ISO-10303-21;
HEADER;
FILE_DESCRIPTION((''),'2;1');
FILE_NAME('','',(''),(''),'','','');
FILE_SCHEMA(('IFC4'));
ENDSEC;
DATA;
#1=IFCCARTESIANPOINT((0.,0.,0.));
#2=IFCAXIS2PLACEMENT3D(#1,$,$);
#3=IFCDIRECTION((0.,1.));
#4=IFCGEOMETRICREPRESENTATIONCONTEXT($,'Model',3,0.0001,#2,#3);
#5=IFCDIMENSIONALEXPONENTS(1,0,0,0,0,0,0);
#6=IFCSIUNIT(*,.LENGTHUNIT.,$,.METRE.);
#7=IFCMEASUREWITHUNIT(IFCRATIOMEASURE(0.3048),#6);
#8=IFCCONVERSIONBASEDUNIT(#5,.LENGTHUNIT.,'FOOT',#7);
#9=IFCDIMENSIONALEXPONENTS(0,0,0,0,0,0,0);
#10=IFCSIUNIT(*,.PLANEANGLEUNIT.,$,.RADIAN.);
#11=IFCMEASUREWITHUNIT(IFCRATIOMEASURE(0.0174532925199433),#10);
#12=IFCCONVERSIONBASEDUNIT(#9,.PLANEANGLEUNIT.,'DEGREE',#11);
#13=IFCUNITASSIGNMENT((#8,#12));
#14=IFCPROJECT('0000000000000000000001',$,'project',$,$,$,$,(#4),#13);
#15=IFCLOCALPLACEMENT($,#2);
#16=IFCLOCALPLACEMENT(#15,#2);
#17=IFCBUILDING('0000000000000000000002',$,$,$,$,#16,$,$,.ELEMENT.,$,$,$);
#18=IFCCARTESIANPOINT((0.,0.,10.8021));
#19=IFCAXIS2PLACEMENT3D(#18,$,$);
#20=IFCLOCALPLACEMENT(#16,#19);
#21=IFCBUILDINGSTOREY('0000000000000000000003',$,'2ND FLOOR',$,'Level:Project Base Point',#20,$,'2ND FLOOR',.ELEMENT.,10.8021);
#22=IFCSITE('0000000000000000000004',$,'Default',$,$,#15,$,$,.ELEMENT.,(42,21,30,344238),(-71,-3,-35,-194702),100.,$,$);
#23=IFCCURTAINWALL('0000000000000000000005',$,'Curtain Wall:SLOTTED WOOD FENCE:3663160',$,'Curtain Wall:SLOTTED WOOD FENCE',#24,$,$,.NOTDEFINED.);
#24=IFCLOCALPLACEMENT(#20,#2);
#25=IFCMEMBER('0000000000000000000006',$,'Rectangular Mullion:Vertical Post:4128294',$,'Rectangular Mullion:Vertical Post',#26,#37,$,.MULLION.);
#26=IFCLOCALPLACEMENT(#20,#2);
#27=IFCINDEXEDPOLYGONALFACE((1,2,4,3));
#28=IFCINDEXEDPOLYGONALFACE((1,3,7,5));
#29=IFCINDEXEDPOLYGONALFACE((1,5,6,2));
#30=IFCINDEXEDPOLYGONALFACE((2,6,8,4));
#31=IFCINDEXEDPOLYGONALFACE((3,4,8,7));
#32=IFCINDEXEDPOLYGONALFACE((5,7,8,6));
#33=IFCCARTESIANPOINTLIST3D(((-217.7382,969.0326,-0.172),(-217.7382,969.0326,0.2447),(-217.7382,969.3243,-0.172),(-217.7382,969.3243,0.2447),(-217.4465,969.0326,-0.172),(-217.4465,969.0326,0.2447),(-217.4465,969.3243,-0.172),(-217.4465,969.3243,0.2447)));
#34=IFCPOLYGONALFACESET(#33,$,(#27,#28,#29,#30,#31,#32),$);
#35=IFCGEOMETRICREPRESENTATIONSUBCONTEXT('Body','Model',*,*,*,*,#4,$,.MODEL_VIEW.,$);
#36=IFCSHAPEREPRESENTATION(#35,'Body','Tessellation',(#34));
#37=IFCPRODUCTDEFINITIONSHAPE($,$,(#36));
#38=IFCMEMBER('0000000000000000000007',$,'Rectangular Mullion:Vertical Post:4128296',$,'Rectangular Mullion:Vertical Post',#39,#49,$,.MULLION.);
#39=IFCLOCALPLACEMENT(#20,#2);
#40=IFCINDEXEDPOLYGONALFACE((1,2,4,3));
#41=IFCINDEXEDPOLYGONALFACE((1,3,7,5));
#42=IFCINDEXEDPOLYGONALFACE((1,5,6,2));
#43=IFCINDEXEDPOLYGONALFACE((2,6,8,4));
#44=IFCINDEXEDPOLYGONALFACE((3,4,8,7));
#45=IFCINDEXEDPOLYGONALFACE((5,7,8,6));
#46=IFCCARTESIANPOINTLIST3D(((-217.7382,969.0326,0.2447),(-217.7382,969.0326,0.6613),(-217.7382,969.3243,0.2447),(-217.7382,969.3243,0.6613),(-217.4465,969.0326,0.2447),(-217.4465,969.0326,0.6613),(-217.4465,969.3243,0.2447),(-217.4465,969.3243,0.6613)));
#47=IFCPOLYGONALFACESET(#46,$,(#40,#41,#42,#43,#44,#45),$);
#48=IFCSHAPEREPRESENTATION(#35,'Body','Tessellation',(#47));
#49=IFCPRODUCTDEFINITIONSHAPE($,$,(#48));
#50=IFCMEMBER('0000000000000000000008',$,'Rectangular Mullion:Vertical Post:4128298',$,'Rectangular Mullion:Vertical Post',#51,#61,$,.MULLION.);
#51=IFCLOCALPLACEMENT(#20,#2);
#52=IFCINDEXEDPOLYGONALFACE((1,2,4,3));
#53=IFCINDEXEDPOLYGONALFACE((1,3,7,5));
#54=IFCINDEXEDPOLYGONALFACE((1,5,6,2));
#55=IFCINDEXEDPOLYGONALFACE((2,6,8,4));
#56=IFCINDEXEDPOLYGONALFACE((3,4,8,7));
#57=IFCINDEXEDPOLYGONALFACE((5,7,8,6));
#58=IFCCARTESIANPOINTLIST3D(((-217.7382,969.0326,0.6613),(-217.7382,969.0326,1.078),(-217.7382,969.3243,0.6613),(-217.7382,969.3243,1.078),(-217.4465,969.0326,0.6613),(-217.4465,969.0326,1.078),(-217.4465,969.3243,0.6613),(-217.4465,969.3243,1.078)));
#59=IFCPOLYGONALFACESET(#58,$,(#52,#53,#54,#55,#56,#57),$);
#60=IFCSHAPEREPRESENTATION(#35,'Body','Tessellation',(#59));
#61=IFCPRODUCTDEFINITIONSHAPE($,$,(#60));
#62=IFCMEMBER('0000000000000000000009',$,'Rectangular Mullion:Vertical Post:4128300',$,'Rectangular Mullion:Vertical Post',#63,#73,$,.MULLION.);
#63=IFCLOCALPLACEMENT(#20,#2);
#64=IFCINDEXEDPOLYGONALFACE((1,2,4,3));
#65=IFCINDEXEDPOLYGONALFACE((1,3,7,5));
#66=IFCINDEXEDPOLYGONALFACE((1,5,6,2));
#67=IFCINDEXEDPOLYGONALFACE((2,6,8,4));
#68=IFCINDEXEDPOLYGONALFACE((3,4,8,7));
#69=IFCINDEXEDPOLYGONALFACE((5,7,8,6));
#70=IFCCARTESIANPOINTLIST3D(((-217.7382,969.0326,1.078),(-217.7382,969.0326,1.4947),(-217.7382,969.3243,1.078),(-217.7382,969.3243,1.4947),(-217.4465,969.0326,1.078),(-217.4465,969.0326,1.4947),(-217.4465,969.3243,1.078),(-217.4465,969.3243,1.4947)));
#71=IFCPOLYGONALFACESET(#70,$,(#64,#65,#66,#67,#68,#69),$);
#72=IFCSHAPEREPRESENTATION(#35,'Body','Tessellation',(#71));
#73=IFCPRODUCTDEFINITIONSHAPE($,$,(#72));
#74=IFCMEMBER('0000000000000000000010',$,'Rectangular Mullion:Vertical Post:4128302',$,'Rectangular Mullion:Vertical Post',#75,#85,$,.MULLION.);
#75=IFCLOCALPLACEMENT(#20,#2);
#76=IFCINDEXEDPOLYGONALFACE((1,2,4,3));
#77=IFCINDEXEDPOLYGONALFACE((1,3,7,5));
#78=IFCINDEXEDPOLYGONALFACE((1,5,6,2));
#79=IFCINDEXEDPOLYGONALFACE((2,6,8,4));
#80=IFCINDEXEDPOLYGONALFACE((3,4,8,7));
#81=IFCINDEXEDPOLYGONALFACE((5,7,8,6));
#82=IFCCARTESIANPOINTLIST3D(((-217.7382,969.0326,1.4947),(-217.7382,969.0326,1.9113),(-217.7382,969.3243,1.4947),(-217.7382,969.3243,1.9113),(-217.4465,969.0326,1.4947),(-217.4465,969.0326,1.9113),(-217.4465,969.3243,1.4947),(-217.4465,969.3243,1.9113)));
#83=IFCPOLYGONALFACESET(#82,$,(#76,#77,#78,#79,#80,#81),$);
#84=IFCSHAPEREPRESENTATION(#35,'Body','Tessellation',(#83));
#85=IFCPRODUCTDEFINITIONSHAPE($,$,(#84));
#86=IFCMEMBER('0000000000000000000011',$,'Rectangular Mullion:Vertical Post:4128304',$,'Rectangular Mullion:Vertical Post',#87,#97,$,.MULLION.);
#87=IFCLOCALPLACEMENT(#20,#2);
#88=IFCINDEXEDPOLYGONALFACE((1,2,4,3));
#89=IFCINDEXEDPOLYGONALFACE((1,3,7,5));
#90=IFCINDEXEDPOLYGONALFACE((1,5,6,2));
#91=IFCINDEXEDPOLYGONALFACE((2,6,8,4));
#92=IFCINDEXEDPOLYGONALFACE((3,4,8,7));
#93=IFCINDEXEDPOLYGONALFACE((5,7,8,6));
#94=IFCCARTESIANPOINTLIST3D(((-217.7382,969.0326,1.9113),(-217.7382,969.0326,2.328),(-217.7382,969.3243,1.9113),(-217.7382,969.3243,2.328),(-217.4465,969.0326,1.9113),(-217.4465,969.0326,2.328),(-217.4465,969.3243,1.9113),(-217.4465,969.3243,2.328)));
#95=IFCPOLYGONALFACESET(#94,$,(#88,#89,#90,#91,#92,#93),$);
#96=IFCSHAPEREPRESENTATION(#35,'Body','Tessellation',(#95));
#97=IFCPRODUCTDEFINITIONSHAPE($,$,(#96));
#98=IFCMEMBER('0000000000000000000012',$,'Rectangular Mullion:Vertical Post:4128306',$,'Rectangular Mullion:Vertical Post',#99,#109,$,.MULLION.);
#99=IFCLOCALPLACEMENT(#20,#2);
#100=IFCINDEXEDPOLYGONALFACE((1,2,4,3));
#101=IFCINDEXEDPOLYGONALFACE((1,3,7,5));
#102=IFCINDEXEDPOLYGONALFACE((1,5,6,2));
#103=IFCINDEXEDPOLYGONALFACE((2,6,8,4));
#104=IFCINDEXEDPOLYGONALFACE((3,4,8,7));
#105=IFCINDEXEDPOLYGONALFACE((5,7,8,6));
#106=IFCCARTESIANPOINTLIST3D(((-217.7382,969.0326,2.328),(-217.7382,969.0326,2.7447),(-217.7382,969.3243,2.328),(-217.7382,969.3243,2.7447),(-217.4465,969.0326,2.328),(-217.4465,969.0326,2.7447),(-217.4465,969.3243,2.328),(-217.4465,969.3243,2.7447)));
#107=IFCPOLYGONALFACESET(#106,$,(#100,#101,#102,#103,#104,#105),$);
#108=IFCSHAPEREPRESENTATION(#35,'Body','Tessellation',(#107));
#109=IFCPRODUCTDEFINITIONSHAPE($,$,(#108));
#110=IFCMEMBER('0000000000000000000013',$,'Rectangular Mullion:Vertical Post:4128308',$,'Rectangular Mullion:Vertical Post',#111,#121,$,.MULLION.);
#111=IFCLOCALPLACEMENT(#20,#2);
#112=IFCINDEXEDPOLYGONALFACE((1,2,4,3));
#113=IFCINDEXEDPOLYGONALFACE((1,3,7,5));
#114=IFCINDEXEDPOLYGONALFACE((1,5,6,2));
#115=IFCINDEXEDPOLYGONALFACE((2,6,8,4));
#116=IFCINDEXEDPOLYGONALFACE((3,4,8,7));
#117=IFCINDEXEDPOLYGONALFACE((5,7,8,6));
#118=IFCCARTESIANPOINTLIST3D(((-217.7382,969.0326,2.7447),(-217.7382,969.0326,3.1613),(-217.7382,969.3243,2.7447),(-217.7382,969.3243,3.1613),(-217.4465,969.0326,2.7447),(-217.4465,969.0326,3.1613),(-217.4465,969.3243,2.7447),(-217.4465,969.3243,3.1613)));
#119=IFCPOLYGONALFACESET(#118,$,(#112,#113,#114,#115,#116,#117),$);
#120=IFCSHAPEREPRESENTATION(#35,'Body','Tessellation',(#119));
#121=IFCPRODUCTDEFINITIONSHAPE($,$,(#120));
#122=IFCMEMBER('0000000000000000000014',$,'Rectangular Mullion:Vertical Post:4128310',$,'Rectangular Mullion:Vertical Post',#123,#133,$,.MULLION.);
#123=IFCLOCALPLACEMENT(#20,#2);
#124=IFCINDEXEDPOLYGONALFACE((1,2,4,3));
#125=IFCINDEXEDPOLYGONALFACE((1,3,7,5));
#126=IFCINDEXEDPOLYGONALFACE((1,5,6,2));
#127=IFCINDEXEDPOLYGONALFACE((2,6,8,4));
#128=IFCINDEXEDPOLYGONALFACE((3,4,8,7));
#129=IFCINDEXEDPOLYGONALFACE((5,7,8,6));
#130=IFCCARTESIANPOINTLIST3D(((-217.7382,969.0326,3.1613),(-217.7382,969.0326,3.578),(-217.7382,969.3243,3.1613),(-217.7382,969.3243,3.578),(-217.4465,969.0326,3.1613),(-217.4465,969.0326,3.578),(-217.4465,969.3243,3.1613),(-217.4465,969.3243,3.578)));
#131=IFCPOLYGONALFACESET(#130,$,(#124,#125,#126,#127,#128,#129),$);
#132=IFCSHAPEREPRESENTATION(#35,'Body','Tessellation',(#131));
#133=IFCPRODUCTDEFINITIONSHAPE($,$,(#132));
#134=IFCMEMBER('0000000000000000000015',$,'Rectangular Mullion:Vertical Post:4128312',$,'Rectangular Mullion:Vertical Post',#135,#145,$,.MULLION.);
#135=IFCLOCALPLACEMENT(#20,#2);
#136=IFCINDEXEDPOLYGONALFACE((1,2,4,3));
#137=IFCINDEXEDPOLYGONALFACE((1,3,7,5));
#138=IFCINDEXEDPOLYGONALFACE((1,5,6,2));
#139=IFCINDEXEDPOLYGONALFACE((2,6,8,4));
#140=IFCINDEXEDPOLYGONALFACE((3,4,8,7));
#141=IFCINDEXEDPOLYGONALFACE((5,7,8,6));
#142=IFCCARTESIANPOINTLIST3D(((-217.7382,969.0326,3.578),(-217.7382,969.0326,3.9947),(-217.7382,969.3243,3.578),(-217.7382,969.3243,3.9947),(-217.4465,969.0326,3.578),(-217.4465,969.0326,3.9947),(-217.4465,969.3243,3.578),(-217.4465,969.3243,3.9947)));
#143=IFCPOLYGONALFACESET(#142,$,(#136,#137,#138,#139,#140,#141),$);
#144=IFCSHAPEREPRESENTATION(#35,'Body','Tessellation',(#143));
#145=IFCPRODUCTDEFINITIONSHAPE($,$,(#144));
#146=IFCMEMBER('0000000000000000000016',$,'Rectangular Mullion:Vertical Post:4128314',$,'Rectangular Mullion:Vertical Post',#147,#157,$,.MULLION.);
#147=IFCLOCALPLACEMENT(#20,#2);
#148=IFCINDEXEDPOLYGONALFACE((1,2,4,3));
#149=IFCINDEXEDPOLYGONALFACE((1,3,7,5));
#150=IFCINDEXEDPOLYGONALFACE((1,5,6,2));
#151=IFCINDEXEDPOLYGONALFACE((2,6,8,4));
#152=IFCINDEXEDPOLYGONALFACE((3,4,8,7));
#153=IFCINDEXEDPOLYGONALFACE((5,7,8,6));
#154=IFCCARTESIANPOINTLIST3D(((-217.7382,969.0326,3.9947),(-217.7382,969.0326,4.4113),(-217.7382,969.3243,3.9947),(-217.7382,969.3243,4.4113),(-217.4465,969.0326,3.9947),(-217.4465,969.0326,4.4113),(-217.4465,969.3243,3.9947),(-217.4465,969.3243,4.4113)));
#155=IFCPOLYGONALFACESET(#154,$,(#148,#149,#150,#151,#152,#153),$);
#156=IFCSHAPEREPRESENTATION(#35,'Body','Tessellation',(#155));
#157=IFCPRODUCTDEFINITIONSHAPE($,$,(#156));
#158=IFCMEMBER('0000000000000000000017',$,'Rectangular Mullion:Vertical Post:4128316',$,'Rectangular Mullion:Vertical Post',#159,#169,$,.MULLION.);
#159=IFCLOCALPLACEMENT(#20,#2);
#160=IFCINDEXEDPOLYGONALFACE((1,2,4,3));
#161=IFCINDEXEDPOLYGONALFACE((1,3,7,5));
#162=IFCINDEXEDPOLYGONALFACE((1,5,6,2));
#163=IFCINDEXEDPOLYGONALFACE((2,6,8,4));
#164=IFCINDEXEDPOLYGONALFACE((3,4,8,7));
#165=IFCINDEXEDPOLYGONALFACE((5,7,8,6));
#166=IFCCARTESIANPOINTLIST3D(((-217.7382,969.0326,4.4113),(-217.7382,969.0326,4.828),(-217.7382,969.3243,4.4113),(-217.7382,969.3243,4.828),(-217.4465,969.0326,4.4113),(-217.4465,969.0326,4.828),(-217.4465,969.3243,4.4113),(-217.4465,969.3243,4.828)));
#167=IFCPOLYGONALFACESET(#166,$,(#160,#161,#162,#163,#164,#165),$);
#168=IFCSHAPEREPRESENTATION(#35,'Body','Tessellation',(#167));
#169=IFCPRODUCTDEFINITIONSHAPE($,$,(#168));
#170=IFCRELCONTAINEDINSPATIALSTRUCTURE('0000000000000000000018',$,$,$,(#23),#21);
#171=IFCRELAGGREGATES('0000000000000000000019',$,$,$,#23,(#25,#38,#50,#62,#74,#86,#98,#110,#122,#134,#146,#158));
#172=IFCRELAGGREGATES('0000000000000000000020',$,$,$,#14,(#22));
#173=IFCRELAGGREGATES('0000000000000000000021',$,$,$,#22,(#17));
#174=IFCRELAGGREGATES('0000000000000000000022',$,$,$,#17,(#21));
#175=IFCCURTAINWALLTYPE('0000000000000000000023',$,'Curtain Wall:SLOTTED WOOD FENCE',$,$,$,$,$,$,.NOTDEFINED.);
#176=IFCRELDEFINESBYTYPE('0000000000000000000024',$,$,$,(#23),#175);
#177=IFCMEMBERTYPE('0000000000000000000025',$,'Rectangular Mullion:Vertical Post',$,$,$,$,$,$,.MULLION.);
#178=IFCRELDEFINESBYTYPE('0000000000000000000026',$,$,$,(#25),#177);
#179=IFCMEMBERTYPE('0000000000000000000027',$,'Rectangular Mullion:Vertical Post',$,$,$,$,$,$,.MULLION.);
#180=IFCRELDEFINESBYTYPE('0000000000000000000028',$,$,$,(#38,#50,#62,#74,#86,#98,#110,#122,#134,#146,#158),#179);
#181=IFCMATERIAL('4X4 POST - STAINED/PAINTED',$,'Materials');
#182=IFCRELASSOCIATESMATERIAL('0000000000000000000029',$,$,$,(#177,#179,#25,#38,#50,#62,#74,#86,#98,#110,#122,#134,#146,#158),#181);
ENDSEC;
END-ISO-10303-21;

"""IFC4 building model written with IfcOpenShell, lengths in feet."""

from ifc_helpers import new_model, entity, si_unit, converted_unit, direction, frame, origin, origin_2d_with_axis, place, context, subcontext, project, spatial, rectangle, extrude, source, transform, mapped, material, material_profile, profile_set, profile_usage, type_object, type_shapes, element, aggregate, save


model = new_model("IFC4")

# Units and contexts
model_context = context("Model", 3, precision=0.0001, world=origin(), true_north=direction((0.0, 1.0)))
body_context = subcontext(model_context, "Body", "Model", "MODEL_VIEW")
ifc_project = project(units=[converted_unit("LENGTHUNIT", "FOOT", entity("IfcRatioMeasure", 0.3048), si_unit("LENGTHUNIT", "METRE"), dimensions=[1, 0, 0, 0, 0, 0, 0]), converted_unit("PLANEANGLEUNIT", "DEGREE", entity("IfcRatioMeasure", 0.0174532925199433), si_unit("PLANEANGLEUNIT", "RADIAN"), dimensions=[0, 0, 0, 0, 0, 0, 0])], contexts=[model_context])

# Site, building, storey
site_placement = place(None, origin())
site = spatial("IfcSite", under=ifc_project, at=site_placement, Name="Default", CompositionType="ELEMENT", RefLatitude=(42, 21, 30, 344238), RefLongitude=(-71, -3, -35, -194702), RefElevation=100.0)
building_placement = place(site_placement, origin())
building = spatial("IfcBuilding", under=site, at=building_placement, CompositionType="ELEMENT")
storey_placement = place(building_placement, frame((0.0, 0.0, 10.8021)))
storey = spatial("IfcBuildingStorey", under=building, at=storey_placement, Name="2ND FLOOR", ObjectType="Level:Project Base Point", LongName="2ND FLOOR", CompositionType="ELEMENT", Elevation=10.8021)

# Curtain wall, members
curtain_wall_type = type_object("IfcCurtainWallType", Name="Curtain Wall:SLOTTED WOOD FENCE", PredefinedType="NOTDEFINED")
curtain_wall_placement = place(storey_placement, frame((0.0, 0.0, -10.8021)))
curtain_wall = element("IfcCurtainWall", 1, at=curtain_wall_placement, inside=storey, type_object=curtain_wall_type, Name="Curtain Wall:SLOTTED WOOD FENCE:3663160", ObjectType="Curtain Wall:SLOTTED WOOD FENCE", PredefinedType="NOTDEFINED")
ifc_material_1 = material(Name="4X4 POST - STAINED/PAINTED", Category="Materials")
ifc_material_profile = material_profile(ifc_material_1, rectangle(XDim=0.2917, YDim=0.2917, at=origin_2d_with_axis()), Name="Vertical Post")
ifc_profile_set = profile_set([ifc_material_profile], Name="Vertical Post")
ifc_profile_usage_1 = profile_usage(ifc_profile_set)
member_type_1 = type_object("IfcMemberType", Name="Rectangular Mullion:Vertical Post", PredefinedType="MULLION", material=ifc_profile_set)
shared_shape_1 = source(origin(), body_context, "Body", "SweptSolid", [
    extrude(rectangle(XDim=0.2917, YDim=0.2917, at=origin_2d_with_axis()), frame((0.0, -0.2083, -0.4167), z_axis=(0.0, 0.0, 1.0), x_axis=(0.0, -1.0, 0.0)), (0.0, 0.0, 1.0), 0.4167),
])
type_shapes(member_type_1, [shared_shape_1])
member_1_placement = place(storey_placement, frame((-217.8007, 969.1784, -0.172), z_axis=(0.0, 0.0, -1.0), x_axis=(0.0, -1.0, 0.0)))
member_1 = element("IfcMember", 2, at=member_1_placement, type_object=member_type_1, material=ifc_profile_usage_1, Name="Rectangular Mullion:Vertical Post:4128294", ObjectType="Rectangular Mullion:Vertical Post", PredefinedType="MULLION", context=body_context, shape_type="MappedRepresentation", body=[
    mapped(shared_shape_1, transform((0.0, 0.0, 0.0), scale=1.0)),
])
ifc_profile_usage_2 = profile_usage(ifc_profile_set)
member_type_2 = type_object("IfcMemberType", Name="Rectangular Mullion:Vertical Post", PredefinedType="MULLION", material=ifc_profile_set)
shared_shape_2 = source(origin(), body_context, "Body", "SweptSolid", [
    extrude(rectangle(XDim=0.2917, YDim=0.2917, at=origin_2d_with_axis()), frame((0.0, -0.2083, -0.4167), z_axis=(0.0, 0.0, 1.0), x_axis=(0.0, -1.0, 0.0)), (0.0, 0.0, 1.0), 0.4167),
])
type_shapes(member_type_2, [shared_shape_2])
member_2_placement = place(storey_placement, frame((-217.8007, 969.1784, 0.2447), z_axis=(0.0, 0.0, -1.0), x_axis=(0.0, -1.0, 0.0)))
member_2 = element("IfcMember", 3, at=member_2_placement, type_object=member_type_2, material=ifc_profile_usage_2, Name="Rectangular Mullion:Vertical Post:4128296", ObjectType="Rectangular Mullion:Vertical Post", PredefinedType="MULLION", context=body_context, shape_type="MappedRepresentation", body=[
    mapped(shared_shape_2, transform((0.0, 0.0, 0.0), scale=1.0)),
])
ifc_profile_usage_3 = profile_usage(ifc_profile_set)
member_3_placement = place(storey_placement, frame((-217.8007, 969.1784, 0.6613), z_axis=(0.0, 0.0, -1.0), x_axis=(0.0, -1.0, 0.0)))
member_3 = element("IfcMember", 4, at=member_3_placement, type_object=member_type_2, material=ifc_profile_usage_3, Name="Rectangular Mullion:Vertical Post:4128298", ObjectType="Rectangular Mullion:Vertical Post", PredefinedType="MULLION", context=body_context, shape_type="MappedRepresentation", body=[
    mapped(shared_shape_2, transform((0.0, 0.0, 0.0), scale=1.0)),
])
ifc_profile_usage_4 = profile_usage(ifc_profile_set)
member_4_placement = place(storey_placement, frame((-217.8007, 969.1784, 1.078), z_axis=(0.0, 0.0, -1.0), x_axis=(0.0, -1.0, 0.0)))
member_4 = element("IfcMember", 5, at=member_4_placement, type_object=member_type_2, material=ifc_profile_usage_4, Name="Rectangular Mullion:Vertical Post:4128300", ObjectType="Rectangular Mullion:Vertical Post", PredefinedType="MULLION", context=body_context, shape_type="MappedRepresentation", body=[
    mapped(shared_shape_2, transform((0.0, 0.0, 0.0), scale=1.0)),
])
ifc_profile_usage_5 = profile_usage(ifc_profile_set)
member_5_placement = place(storey_placement, frame((-217.8007, 969.1784, 1.4947), z_axis=(0.0, 0.0, -1.0), x_axis=(0.0, -1.0, 0.0)))
member_5 = element("IfcMember", 6, at=member_5_placement, type_object=member_type_2, material=ifc_profile_usage_5, Name="Rectangular Mullion:Vertical Post:4128302", ObjectType="Rectangular Mullion:Vertical Post", PredefinedType="MULLION", context=body_context, shape_type="MappedRepresentation", body=[
    mapped(shared_shape_2, transform((0.0, 0.0, 0.0), scale=1.0)),
])
ifc_profile_usage_6 = profile_usage(ifc_profile_set)
member_6_placement = place(storey_placement, frame((-217.8007, 969.1784, 1.9113), z_axis=(0.0, 0.0, -1.0), x_axis=(0.0, -1.0, 0.0)))
member_6 = element("IfcMember", 7, at=member_6_placement, type_object=member_type_2, material=ifc_profile_usage_6, Name="Rectangular Mullion:Vertical Post:4128304", ObjectType="Rectangular Mullion:Vertical Post", PredefinedType="MULLION", context=body_context, shape_type="MappedRepresentation", body=[
    mapped(shared_shape_2, transform((0.0, 0.0, 0.0), scale=1.0)),
])
ifc_profile_usage_7 = profile_usage(ifc_profile_set)
member_7_placement = place(storey_placement, frame((-217.8007, 969.1784, 2.328), z_axis=(0.0, 0.0, -1.0), x_axis=(0.0, -1.0, 0.0)))
member_7 = element("IfcMember", 8, at=member_7_placement, type_object=member_type_2, material=ifc_profile_usage_7, Name="Rectangular Mullion:Vertical Post:4128306", ObjectType="Rectangular Mullion:Vertical Post", PredefinedType="MULLION", context=body_context, shape_type="MappedRepresentation", body=[
    mapped(shared_shape_2, transform((0.0, 0.0, 0.0), scale=1.0)),
])
ifc_profile_usage_8 = profile_usage(ifc_profile_set)
member_8_placement = place(storey_placement, frame((-217.8007, 969.1784, 2.7447), z_axis=(0.0, 0.0, -1.0), x_axis=(0.0, -1.0, 0.0)))
member_8 = element("IfcMember", 9, at=member_8_placement, type_object=member_type_2, material=ifc_profile_usage_8, Name="Rectangular Mullion:Vertical Post:4128308", ObjectType="Rectangular Mullion:Vertical Post", PredefinedType="MULLION", context=body_context, shape_type="MappedRepresentation", body=[
    mapped(shared_shape_2, transform((0.0, 0.0, 0.0), scale=1.0)),
])
ifc_profile_usage_9 = profile_usage(ifc_profile_set)
member_9_placement = place(storey_placement, frame((-217.8007, 969.1784, 3.1613), z_axis=(0.0, 0.0, -1.0), x_axis=(0.0, -1.0, 0.0)))
member_9 = element("IfcMember", 10, at=member_9_placement, type_object=member_type_2, material=ifc_profile_usage_9, Name="Rectangular Mullion:Vertical Post:4128310", ObjectType="Rectangular Mullion:Vertical Post", PredefinedType="MULLION", context=body_context, shape_type="MappedRepresentation", body=[
    mapped(shared_shape_2, transform((0.0, 0.0, 0.0), scale=1.0)),
])
ifc_profile_usage_10 = profile_usage(ifc_profile_set)
member_10_placement = place(storey_placement, frame((-217.8007, 969.1784, 3.578), z_axis=(0.0, 0.0, -1.0), x_axis=(0.0, -1.0, 0.0)))
member_10 = element("IfcMember", 11, at=member_10_placement, type_object=member_type_2, material=ifc_profile_usage_10, Name="Rectangular Mullion:Vertical Post:4128312", ObjectType="Rectangular Mullion:Vertical Post", PredefinedType="MULLION", context=body_context, shape_type="MappedRepresentation", body=[
    mapped(shared_shape_2, transform((0.0, 0.0, 0.0), scale=1.0)),
])
ifc_profile_usage_11 = profile_usage(ifc_profile_set)
member_11_placement = place(storey_placement, frame((-217.8007, 969.1784, 3.9947), z_axis=(0.0, 0.0, -1.0), x_axis=(0.0, -1.0, 0.0)))
member_11 = element("IfcMember", 12, at=member_11_placement, type_object=member_type_2, material=ifc_profile_usage_11, Name="Rectangular Mullion:Vertical Post:4128314", ObjectType="Rectangular Mullion:Vertical Post", PredefinedType="MULLION", context=body_context, shape_type="MappedRepresentation", body=[
    mapped(shared_shape_2, transform((0.0, 0.0, 0.0), scale=1.0)),
])
ifc_profile_usage_12 = profile_usage(ifc_profile_set)
member_12_placement = place(storey_placement, frame((-217.8007, 969.1784, 4.4113), z_axis=(0.0, 0.0, -1.0), x_axis=(0.0, -1.0, 0.0)))
member_12 = element("IfcMember", 13, at=member_12_placement, type_object=member_type_2, material=ifc_profile_usage_12, Name="Rectangular Mullion:Vertical Post:4128316", ObjectType="Rectangular Mullion:Vertical Post", PredefinedType="MULLION", context=body_context, shape_type="MappedRepresentation", body=[
    mapped(shared_shape_2, transform((0.0, 0.0, 0.0), scale=1.0)),
])
aggregate(curtain_wall, [member_1, member_2, member_3, member_4, member_5, member_6, member_7, member_8, member_9, member_10, member_11, member_12])

save(model, "model.ifc")
